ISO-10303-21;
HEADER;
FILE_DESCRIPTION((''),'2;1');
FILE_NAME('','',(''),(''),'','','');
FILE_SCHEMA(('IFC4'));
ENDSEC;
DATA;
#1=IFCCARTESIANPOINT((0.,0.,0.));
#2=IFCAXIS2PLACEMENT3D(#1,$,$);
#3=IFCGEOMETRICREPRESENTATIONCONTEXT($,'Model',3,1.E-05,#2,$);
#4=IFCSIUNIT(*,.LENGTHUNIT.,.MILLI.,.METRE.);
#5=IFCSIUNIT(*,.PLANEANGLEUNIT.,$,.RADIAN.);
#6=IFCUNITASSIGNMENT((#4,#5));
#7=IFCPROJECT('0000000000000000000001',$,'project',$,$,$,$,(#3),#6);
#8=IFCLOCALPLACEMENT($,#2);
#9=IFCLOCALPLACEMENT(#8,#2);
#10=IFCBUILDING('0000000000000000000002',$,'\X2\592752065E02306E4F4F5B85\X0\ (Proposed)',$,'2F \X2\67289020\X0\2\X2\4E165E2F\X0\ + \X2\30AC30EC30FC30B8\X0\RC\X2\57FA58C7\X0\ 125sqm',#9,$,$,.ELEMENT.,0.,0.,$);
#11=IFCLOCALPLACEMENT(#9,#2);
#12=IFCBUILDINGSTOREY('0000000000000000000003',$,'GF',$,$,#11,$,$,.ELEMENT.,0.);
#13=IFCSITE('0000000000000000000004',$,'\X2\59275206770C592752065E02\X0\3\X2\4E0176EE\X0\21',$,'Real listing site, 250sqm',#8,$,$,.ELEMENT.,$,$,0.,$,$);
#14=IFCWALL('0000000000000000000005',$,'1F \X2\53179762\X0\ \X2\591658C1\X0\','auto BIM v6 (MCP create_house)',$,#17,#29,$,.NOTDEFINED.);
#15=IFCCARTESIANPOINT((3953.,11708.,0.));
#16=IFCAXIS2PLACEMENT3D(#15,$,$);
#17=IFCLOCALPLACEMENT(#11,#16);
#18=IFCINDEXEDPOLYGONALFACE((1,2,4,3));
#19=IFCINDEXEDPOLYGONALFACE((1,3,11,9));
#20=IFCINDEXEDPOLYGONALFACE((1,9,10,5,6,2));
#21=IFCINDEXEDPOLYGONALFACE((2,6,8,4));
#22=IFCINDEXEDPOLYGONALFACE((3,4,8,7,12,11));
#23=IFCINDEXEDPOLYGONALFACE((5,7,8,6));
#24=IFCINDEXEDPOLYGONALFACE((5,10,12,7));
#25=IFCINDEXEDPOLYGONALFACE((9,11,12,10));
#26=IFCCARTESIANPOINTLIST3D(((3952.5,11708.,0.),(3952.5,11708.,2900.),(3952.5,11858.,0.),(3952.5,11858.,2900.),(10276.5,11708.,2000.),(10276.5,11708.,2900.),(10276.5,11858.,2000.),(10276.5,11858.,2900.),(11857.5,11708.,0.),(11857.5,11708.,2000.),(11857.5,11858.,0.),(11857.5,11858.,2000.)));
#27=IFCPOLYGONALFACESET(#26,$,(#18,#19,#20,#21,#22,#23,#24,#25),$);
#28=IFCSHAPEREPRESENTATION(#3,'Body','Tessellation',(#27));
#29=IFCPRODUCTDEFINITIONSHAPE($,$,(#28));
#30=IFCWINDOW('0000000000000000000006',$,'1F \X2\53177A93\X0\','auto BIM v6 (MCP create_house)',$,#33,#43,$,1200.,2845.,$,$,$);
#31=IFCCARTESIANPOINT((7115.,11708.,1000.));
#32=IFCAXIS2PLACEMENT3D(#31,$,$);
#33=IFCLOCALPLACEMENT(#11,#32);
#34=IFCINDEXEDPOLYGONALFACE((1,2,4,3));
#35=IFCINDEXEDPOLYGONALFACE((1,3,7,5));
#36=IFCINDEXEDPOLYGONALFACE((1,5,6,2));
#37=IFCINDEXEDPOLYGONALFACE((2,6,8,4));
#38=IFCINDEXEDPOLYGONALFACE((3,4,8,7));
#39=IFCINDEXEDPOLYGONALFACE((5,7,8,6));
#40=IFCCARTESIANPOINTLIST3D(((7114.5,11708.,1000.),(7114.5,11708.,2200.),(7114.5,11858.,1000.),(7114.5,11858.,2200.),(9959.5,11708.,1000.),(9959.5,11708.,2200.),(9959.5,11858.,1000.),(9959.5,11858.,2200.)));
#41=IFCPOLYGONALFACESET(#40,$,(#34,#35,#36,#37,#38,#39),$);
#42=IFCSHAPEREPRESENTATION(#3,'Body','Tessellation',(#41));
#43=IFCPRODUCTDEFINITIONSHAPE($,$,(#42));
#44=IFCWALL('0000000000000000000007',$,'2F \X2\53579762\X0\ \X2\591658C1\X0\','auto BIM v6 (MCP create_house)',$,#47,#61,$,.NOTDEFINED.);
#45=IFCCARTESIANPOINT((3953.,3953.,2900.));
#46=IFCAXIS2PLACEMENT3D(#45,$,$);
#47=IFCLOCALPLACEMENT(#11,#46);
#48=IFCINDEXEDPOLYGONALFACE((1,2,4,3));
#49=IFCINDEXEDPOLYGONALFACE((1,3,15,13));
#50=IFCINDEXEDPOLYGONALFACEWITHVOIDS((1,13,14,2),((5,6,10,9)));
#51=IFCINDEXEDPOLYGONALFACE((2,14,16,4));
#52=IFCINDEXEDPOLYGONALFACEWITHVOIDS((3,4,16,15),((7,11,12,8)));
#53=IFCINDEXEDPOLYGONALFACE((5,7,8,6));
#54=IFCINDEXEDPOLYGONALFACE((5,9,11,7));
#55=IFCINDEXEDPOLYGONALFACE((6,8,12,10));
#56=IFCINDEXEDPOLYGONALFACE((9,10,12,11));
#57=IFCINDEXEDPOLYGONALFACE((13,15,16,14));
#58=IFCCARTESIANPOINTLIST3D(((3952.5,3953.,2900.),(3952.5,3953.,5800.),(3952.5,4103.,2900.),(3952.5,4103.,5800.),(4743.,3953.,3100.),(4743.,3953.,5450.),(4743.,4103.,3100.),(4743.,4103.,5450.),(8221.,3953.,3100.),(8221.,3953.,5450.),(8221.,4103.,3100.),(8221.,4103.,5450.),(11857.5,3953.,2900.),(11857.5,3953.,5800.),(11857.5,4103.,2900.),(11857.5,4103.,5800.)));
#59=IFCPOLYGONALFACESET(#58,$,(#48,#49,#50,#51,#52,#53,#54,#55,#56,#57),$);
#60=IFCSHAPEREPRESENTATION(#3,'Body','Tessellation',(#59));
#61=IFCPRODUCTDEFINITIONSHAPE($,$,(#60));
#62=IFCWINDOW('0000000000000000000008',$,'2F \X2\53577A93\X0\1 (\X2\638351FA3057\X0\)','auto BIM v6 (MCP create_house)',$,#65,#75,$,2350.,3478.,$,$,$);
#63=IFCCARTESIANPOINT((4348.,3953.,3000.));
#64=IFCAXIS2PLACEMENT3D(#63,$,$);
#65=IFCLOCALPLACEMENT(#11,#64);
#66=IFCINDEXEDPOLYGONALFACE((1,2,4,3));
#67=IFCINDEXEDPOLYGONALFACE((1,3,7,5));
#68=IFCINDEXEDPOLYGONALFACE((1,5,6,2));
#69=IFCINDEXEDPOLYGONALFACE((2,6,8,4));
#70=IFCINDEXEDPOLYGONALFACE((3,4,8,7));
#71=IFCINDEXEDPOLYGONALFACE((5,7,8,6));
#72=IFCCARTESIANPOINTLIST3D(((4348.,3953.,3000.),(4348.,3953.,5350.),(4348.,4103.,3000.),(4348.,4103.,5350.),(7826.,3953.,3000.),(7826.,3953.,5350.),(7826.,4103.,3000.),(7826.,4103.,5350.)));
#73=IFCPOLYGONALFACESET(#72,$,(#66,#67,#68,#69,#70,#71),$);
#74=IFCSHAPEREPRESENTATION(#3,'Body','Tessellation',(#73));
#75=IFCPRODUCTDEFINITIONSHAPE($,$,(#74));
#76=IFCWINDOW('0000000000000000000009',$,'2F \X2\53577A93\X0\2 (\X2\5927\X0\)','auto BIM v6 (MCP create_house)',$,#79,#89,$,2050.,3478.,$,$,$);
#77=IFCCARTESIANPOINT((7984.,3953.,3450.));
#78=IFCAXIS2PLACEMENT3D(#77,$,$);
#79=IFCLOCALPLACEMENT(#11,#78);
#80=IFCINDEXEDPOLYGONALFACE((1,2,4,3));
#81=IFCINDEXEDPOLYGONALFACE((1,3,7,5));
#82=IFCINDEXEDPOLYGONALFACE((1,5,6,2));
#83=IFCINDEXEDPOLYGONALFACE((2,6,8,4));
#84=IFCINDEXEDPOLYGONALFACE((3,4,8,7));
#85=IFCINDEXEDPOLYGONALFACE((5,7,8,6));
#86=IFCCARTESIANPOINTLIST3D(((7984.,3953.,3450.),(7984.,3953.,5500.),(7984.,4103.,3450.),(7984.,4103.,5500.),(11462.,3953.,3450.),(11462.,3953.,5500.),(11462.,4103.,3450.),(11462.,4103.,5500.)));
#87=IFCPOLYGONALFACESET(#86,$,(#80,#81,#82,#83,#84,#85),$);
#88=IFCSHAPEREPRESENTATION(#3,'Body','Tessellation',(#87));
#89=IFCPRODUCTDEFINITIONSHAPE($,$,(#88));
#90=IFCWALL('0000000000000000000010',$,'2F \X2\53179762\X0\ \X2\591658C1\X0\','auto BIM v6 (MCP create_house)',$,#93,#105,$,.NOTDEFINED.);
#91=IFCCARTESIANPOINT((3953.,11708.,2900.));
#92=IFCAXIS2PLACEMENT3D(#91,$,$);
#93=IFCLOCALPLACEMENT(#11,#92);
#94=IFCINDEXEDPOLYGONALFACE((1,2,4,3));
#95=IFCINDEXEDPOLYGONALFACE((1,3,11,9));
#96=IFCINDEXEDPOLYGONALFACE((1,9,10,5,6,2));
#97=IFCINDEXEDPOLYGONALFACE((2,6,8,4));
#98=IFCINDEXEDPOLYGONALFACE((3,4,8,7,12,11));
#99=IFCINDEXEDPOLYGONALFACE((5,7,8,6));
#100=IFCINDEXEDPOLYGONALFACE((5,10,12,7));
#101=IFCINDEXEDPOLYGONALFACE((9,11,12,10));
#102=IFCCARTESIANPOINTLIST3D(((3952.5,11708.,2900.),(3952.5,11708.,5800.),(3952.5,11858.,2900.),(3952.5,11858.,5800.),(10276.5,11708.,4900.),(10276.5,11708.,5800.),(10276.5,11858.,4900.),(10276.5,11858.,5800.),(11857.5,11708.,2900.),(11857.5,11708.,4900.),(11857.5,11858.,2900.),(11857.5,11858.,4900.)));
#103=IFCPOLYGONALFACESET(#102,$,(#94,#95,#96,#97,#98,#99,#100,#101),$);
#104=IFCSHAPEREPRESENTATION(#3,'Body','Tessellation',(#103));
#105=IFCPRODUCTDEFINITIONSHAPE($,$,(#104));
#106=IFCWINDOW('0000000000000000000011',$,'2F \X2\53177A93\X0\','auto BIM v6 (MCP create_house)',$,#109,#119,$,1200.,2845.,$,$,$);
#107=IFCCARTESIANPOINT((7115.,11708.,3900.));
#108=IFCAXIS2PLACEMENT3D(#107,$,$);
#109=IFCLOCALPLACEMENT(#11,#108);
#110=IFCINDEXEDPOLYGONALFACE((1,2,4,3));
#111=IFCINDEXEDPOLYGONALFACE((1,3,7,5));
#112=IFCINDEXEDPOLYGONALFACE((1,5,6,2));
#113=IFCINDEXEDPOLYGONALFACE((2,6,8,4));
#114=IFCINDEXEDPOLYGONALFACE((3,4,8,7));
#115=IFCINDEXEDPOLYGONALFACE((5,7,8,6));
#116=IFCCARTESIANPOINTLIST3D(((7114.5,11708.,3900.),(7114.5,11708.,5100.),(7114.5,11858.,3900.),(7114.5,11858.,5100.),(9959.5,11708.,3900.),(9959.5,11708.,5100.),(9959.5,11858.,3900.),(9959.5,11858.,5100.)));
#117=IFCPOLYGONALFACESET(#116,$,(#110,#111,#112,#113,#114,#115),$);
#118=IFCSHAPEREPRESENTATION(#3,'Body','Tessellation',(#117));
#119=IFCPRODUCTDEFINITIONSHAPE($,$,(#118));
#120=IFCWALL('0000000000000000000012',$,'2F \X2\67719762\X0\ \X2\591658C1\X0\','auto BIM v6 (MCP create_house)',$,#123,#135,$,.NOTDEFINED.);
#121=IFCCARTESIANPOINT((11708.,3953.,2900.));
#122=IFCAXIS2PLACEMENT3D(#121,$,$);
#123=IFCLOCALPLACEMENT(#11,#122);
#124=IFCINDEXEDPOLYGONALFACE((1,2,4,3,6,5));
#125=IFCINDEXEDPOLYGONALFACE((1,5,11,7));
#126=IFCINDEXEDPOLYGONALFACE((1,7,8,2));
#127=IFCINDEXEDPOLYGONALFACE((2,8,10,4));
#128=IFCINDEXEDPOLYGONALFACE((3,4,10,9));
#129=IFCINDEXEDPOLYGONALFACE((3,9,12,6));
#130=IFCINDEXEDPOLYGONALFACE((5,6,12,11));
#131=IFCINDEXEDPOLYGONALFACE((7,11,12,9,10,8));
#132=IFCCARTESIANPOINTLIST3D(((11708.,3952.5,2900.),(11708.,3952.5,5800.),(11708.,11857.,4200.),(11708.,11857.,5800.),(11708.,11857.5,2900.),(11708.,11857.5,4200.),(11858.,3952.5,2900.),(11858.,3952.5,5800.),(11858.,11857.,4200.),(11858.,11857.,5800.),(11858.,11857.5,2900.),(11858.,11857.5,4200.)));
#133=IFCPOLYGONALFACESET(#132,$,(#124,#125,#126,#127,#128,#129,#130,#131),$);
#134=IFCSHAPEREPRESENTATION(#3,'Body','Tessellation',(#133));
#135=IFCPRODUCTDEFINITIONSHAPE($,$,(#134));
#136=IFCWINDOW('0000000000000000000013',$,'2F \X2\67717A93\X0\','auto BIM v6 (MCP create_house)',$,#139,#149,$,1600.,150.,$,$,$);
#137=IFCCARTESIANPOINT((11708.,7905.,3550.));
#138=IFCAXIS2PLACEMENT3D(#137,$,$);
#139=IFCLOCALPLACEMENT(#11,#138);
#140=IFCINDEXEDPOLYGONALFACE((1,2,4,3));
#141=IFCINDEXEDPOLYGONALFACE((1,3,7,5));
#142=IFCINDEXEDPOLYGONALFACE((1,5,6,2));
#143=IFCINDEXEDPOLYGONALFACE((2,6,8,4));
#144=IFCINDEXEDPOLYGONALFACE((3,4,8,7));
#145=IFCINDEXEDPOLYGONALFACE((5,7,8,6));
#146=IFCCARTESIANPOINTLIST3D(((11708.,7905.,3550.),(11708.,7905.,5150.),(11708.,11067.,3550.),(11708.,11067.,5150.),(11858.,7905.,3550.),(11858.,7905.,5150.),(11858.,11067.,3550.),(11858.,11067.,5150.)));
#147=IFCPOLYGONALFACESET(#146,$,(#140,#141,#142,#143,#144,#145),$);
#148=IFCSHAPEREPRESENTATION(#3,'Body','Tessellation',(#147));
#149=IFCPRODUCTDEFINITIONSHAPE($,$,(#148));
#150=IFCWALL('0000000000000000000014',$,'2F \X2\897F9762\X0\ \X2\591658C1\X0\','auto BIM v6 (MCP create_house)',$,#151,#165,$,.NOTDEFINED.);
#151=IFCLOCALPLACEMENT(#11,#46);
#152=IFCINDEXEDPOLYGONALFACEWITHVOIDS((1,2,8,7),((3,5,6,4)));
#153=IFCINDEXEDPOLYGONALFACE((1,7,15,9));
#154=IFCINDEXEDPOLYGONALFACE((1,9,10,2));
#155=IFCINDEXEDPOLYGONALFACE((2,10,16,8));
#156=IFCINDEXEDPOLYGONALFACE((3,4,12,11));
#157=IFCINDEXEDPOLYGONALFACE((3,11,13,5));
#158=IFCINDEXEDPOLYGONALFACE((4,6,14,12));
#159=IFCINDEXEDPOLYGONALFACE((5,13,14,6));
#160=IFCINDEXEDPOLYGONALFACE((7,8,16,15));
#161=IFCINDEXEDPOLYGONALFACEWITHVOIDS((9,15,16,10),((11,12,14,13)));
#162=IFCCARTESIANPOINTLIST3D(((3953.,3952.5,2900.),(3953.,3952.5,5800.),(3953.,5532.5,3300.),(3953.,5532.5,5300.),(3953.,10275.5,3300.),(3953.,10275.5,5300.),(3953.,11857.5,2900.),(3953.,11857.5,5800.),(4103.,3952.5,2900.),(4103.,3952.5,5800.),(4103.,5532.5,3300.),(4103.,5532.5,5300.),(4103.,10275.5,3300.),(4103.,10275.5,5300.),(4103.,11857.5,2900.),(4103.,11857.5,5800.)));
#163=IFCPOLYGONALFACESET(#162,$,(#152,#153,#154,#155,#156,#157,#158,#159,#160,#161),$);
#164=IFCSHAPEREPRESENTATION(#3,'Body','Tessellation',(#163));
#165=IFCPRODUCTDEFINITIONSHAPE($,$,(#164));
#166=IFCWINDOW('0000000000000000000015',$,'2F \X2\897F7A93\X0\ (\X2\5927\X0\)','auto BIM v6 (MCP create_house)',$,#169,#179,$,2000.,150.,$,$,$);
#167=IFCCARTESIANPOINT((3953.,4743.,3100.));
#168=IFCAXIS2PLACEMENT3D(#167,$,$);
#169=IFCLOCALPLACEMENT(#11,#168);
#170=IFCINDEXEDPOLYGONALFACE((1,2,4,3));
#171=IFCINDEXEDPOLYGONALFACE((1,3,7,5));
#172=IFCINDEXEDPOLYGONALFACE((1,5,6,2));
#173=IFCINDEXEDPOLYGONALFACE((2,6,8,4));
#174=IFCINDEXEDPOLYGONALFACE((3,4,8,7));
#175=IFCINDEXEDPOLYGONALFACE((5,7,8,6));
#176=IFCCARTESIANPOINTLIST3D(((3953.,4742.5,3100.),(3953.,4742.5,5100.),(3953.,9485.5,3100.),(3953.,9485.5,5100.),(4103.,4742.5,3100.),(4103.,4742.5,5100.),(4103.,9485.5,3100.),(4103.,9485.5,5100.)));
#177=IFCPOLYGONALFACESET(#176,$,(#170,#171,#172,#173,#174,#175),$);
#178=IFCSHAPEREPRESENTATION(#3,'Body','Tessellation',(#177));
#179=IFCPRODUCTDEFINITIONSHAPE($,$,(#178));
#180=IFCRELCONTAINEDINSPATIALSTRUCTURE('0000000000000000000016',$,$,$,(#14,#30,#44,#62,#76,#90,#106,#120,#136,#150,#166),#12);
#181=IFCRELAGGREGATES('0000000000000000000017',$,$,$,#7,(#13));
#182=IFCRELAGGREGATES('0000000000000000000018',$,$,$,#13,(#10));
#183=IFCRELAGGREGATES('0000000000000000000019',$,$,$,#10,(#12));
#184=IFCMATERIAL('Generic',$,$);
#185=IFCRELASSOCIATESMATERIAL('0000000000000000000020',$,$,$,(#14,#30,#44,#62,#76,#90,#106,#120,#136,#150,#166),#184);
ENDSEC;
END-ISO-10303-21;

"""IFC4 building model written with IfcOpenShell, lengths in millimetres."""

from ifc_helpers import new_model, si_unit, frame, frame_2d, origin, place, context, project, spatial, rectangle, extrude, material, element, fill, save


model = new_model("IFC4")

# Units and contexts
model_context = context("Model", 3, precision=1e-05, world=origin())
ifc_project = project(units=[si_unit("LENGTHUNIT", "METRE", prefix="MILLI"), si_unit("PLANEANGLEUNIT", "RADIAN")], contexts=[model_context])

# Site, building, storey
site_placement = place(None, origin())
site = spatial("IfcSite", under=ifc_project, at=site_placement, Name="大分県大分市3丁目21", ObjectType="Real listing site, 250sqm", CompositionType="ELEMENT", RefElevation=0.0)
building_placement = place(site_placement, origin())
building = spatial("IfcBuilding", under=site, at=building_placement, Name="大分市の住宅 (Proposed)", ObjectType="2F 木造2世帯 + ガレージRC基壇 125sqm", CompositionType="ELEMENT", ElevationOfRefHeight=0.0, ElevationOfTerrain=0.0)
storey_placement = place(building_placement, origin())
storey = spatial("IfcBuildingStorey", under=building, at=storey_placement, Name="GF", CompositionType="ELEMENT", Elevation=0.0)

# Wall, opening, window
ifc_material = material(Name="Generic")
wall_1_placement = place(storey_placement, frame((3953.0, 11708.0, 0.0)))
wall_1 = element("IfcWall", 1, at=wall_1_placement, inside=storey, material=ifc_material, Name="1F 北面 外壁", Description="auto BIM v6 (MCP create_house)", PredefinedType="NOTDEFINED", context=model_context, shape_type="SweptSolid", body=[
    extrude(rectangle(XDim=7905.0, YDim=150.0, at=frame_2d((3952.0, 75.0))), frame((3953.0, 11708.0, 0.0)), (0.0, 0.0, 1.0), 2900.0),
])
opening_1_placement = place(storey_placement, frame((7115.0, 11708.0, 1000.0)))
opening_1 = element("IfcOpeningElement", 2, at=opening_1_placement, cuts=wall_1, PredefinedType="NOTDEFINED", context=model_context, shape_type="SweptSolid", body=[
    extrude(rectangle(XDim=2845.0, YDim=150.0, at=frame_2d((1422.0, 75.0))), frame((7115.0, 11708.0, 1000.0)), (0.0, 0.0, 1.0), 1200.0),
])
window_1_placement = place(storey_placement, frame((7115.0, 11708.0, 1000.0)))
window_1 = element("IfcWindow", 3, at=window_1_placement, inside=storey, material=ifc_material, Name="1F 北窓", Description="auto BIM v6 (MCP create_house)", OverallHeight=1200.0, OverallWidth=2845.0, context=model_context, shape_type="SweptSolid", body=[
    extrude(rectangle(XDim=2845.0, YDim=150.0, at=frame_2d((1422.0, 75.0))), frame((7115.0, 11708.0, 1000.0)), (0.0, 0.0, 1.0), 1200.0),
])
fill(opening_1, window_1)

# Wall, openings, windows
wall_2_placement = place(storey_placement, frame((3953.0, 3953.0, 2900.0)))
wall_2 = element("IfcWall", 4, at=wall_2_placement, inside=storey, material=ifc_material, Name="2F 南面 外壁", Description="auto BIM v6 (MCP create_house)", PredefinedType="NOTDEFINED", context=model_context, shape_type="SweptSolid", body=[
    extrude(rectangle(XDim=7905.0, YDim=150.0, at=frame_2d((3952.0, 75.0))), frame((3953.0, 3953.0, 2900.0)), (0.0, 0.0, 1.0), 2900.0),
])
opening_2_placement = place(storey_placement, frame((4348.0, 3953.0, 3000.0)))
opening_2 = element("IfcOpeningElement", 5, at=opening_2_placement, cuts=wall_2, PredefinedType="NOTDEFINED", context=model_context, shape_type="SweptSolid", body=[
    extrude(rectangle(XDim=3478.0, YDim=150.0, at=frame_2d((1739.0, 75.0))), frame((4348.0, 3953.0, 3000.0)), (0.0, 0.0, 1.0), 2350.0),
])
opening_3_placement = place(storey_placement, frame((7984.0, 3953.0, 3450.0)))
opening_3 = element("IfcOpeningElement", 6, at=opening_3_placement, cuts=wall_2, PredefinedType="NOTDEFINED", context=model_context, shape_type="SweptSolid", body=[
    extrude(rectangle(XDim=3478.0, YDim=150.0, at=frame_2d((1739.0, 75.0))), frame((7984.0, 3953.0, 3450.0)), (0.0, 0.0, 1.0), 2050.0),
])
window_2_placement = place(storey_placement, frame((4348.0, 3953.0, 3000.0)))
window_2 = element("IfcWindow", 7, at=window_2_placement, inside=storey, material=ifc_material, Name="2F 南窓1 (掃出し)", Description="auto BIM v6 (MCP create_house)", OverallHeight=2350.0, OverallWidth=3478.0, context=model_context, shape_type="SweptSolid", body=[
    extrude(rectangle(XDim=3478.0, YDim=150.0, at=frame_2d((1739.0, 75.0))), frame((4348.0, 3953.0, 3000.0)), (0.0, 0.0, 1.0), 2350.0),
])
fill(opening_2, window_2)
window_3_placement = place(storey_placement, frame((7984.0, 3953.0, 3450.0)))
window_3 = element("IfcWindow", 8, at=window_3_placement, inside=storey, material=ifc_material, Name="2F 南窓2 (大)", Description="auto BIM v6 (MCP create_house)", OverallHeight=2050.0, OverallWidth=3478.0, context=model_context, shape_type="SweptSolid", body=[
    extrude(rectangle(XDim=3478.0, YDim=150.0, at=frame_2d((1739.0, 75.0))), frame((7984.0, 3953.0, 3450.0)), (0.0, 0.0, 1.0), 2050.0),
])
fill(opening_3, window_3)

# Walls, openings, windows
wall_3_placement = place(storey_placement, frame((3953.0, 11708.0, 2900.0)))
wall_3 = element("IfcWall", 9, at=wall_3_placement, inside=storey, material=ifc_material, Name="2F 北面 外壁", Description="auto BIM v6 (MCP create_house)", PredefinedType="NOTDEFINED", context=model_context, shape_type="SweptSolid", body=[
    extrude(rectangle(XDim=7905.0, YDim=150.0, at=frame_2d((3952.0, 75.0))), frame((3953.0, 11708.0, 2900.0)), (0.0, 0.0, 1.0), 2900.0),
])
opening_4_placement = place(storey_placement, frame((7115.0, 11708.0, 3900.0)))
opening_4 = element("IfcOpeningElement", 10, at=opening_4_placement, cuts=wall_3, PredefinedType="NOTDEFINED", context=model_context, shape_type="SweptSolid", body=[
    extrude(rectangle(XDim=2845.0, YDim=150.0, at=frame_2d((1422.0, 75.0))), frame((7115.0, 11708.0, 3900.0)), (0.0, 0.0, 1.0), 1200.0),
])
window_4_placement = place(storey_placement, frame((7115.0, 11708.0, 3900.0)))
window_4 = element("IfcWindow", 11, at=window_4_placement, inside=storey, material=ifc_material, Name="2F 北窓", Description="auto BIM v6 (MCP create_house)", OverallHeight=1200.0, OverallWidth=2845.0, context=model_context, shape_type="SweptSolid", body=[
    extrude(rectangle(XDim=2845.0, YDim=150.0, at=frame_2d((1422.0, 75.0))), frame((7115.0, 11708.0, 3900.0)), (0.0, 0.0, 1.0), 1200.0),
])
fill(opening_4, window_4)
wall_4_placement = place(storey_placement, frame((11708.0, 3953.0, 2900.0)))
wall_4 = element("IfcWall", 12, at=wall_4_placement, inside=storey, material=ifc_material, Name="2F 東面 外壁", Description="auto BIM v6 (MCP create_house)", PredefinedType="NOTDEFINED", context=model_context, shape_type="SweptSolid", body=[
    extrude(rectangle(XDim=150.0, YDim=7905.0, at=frame_2d((75.0, 3952.0))), frame((11708.0, 3953.0, 2900.0)), (0.0, 0.0, 1.0), 2900.0),
])
opening_5_placement = place(storey_placement, frame((11708.0, 7905.0, 3550.0)))
opening_5 = element("IfcOpeningElement", 13, at=opening_5_placement, cuts=wall_4, PredefinedType="NOTDEFINED", context=model_context, shape_type="SweptSolid", body=[
    extrude(rectangle(XDim=150.0, YDim=3162.0, at=frame_2d((75.0, 1581.0))), frame((11708.0, 7905.0, 3550.0)), (0.0, 0.0, 1.0), 1600.0),
])
window_5_placement = place(storey_placement, frame((11708.0, 7905.0, 3550.0)))
window_5 = element("IfcWindow", 14, at=window_5_placement, inside=storey, material=ifc_material, Name="2F 東窓", Description="auto BIM v6 (MCP create_house)", OverallHeight=1600.0, OverallWidth=150.0, context=model_context, shape_type="SweptSolid", body=[
    extrude(rectangle(XDim=150.0, YDim=3162.0, at=frame_2d((75.0, 1581.0))), frame((11708.0, 7905.0, 3550.0)), (0.0, 0.0, 1.0), 1600.0),
])
fill(opening_5, window_5)
wall_5_placement = place(storey_placement, frame((3953.0, 3953.0, 2900.0)))
wall_5 = element("IfcWall", 15, at=wall_5_placement, inside=storey, material=ifc_material, Name="2F 西面 外壁", Description="auto BIM v6 (MCP create_house)", PredefinedType="NOTDEFINED", context=model_context, shape_type="SweptSolid", body=[
    extrude(rectangle(XDim=150.0, YDim=7905.0, at=frame_2d((75.0, 3952.0))), frame((3953.0, 3953.0, 2900.0)), (0.0, 0.0, 1.0), 2900.0),
])
opening_6_placement = place(storey_placement, frame((3953.0, 4743.0, 3100.0)))
opening_6 = element("IfcOpeningElement", 16, at=opening_6_placement, cuts=wall_5, PredefinedType="NOTDEFINED", context=model_context, shape_type="SweptSolid", body=[
    extrude(rectangle(XDim=150.0, YDim=4743.0, at=frame_2d((75.0, 2371.0))), frame((3953.0, 4743.0, 3100.0)), (0.0, 0.0, 1.0), 2000.0),
])
window_6_placement = place(storey_placement, frame((3953.0, 4743.0, 3100.0)))
window_6 = element("IfcWindow", 17, at=window_6_placement, inside=storey, material=ifc_material, Name="2F 西窓 (大)", Description="auto BIM v6 (MCP create_house)", OverallHeight=2000.0, OverallWidth=150.0, context=model_context, shape_type="SweptSolid", body=[
    extrude(rectangle(XDim=150.0, YDim=4743.0, at=frame_2d((75.0, 2371.0))), frame((3953.0, 4743.0, 3100.0)), (0.0, 0.0, 1.0), 2000.0),
])
fill(opening_6, window_6)

save(model, "model.ifc")
